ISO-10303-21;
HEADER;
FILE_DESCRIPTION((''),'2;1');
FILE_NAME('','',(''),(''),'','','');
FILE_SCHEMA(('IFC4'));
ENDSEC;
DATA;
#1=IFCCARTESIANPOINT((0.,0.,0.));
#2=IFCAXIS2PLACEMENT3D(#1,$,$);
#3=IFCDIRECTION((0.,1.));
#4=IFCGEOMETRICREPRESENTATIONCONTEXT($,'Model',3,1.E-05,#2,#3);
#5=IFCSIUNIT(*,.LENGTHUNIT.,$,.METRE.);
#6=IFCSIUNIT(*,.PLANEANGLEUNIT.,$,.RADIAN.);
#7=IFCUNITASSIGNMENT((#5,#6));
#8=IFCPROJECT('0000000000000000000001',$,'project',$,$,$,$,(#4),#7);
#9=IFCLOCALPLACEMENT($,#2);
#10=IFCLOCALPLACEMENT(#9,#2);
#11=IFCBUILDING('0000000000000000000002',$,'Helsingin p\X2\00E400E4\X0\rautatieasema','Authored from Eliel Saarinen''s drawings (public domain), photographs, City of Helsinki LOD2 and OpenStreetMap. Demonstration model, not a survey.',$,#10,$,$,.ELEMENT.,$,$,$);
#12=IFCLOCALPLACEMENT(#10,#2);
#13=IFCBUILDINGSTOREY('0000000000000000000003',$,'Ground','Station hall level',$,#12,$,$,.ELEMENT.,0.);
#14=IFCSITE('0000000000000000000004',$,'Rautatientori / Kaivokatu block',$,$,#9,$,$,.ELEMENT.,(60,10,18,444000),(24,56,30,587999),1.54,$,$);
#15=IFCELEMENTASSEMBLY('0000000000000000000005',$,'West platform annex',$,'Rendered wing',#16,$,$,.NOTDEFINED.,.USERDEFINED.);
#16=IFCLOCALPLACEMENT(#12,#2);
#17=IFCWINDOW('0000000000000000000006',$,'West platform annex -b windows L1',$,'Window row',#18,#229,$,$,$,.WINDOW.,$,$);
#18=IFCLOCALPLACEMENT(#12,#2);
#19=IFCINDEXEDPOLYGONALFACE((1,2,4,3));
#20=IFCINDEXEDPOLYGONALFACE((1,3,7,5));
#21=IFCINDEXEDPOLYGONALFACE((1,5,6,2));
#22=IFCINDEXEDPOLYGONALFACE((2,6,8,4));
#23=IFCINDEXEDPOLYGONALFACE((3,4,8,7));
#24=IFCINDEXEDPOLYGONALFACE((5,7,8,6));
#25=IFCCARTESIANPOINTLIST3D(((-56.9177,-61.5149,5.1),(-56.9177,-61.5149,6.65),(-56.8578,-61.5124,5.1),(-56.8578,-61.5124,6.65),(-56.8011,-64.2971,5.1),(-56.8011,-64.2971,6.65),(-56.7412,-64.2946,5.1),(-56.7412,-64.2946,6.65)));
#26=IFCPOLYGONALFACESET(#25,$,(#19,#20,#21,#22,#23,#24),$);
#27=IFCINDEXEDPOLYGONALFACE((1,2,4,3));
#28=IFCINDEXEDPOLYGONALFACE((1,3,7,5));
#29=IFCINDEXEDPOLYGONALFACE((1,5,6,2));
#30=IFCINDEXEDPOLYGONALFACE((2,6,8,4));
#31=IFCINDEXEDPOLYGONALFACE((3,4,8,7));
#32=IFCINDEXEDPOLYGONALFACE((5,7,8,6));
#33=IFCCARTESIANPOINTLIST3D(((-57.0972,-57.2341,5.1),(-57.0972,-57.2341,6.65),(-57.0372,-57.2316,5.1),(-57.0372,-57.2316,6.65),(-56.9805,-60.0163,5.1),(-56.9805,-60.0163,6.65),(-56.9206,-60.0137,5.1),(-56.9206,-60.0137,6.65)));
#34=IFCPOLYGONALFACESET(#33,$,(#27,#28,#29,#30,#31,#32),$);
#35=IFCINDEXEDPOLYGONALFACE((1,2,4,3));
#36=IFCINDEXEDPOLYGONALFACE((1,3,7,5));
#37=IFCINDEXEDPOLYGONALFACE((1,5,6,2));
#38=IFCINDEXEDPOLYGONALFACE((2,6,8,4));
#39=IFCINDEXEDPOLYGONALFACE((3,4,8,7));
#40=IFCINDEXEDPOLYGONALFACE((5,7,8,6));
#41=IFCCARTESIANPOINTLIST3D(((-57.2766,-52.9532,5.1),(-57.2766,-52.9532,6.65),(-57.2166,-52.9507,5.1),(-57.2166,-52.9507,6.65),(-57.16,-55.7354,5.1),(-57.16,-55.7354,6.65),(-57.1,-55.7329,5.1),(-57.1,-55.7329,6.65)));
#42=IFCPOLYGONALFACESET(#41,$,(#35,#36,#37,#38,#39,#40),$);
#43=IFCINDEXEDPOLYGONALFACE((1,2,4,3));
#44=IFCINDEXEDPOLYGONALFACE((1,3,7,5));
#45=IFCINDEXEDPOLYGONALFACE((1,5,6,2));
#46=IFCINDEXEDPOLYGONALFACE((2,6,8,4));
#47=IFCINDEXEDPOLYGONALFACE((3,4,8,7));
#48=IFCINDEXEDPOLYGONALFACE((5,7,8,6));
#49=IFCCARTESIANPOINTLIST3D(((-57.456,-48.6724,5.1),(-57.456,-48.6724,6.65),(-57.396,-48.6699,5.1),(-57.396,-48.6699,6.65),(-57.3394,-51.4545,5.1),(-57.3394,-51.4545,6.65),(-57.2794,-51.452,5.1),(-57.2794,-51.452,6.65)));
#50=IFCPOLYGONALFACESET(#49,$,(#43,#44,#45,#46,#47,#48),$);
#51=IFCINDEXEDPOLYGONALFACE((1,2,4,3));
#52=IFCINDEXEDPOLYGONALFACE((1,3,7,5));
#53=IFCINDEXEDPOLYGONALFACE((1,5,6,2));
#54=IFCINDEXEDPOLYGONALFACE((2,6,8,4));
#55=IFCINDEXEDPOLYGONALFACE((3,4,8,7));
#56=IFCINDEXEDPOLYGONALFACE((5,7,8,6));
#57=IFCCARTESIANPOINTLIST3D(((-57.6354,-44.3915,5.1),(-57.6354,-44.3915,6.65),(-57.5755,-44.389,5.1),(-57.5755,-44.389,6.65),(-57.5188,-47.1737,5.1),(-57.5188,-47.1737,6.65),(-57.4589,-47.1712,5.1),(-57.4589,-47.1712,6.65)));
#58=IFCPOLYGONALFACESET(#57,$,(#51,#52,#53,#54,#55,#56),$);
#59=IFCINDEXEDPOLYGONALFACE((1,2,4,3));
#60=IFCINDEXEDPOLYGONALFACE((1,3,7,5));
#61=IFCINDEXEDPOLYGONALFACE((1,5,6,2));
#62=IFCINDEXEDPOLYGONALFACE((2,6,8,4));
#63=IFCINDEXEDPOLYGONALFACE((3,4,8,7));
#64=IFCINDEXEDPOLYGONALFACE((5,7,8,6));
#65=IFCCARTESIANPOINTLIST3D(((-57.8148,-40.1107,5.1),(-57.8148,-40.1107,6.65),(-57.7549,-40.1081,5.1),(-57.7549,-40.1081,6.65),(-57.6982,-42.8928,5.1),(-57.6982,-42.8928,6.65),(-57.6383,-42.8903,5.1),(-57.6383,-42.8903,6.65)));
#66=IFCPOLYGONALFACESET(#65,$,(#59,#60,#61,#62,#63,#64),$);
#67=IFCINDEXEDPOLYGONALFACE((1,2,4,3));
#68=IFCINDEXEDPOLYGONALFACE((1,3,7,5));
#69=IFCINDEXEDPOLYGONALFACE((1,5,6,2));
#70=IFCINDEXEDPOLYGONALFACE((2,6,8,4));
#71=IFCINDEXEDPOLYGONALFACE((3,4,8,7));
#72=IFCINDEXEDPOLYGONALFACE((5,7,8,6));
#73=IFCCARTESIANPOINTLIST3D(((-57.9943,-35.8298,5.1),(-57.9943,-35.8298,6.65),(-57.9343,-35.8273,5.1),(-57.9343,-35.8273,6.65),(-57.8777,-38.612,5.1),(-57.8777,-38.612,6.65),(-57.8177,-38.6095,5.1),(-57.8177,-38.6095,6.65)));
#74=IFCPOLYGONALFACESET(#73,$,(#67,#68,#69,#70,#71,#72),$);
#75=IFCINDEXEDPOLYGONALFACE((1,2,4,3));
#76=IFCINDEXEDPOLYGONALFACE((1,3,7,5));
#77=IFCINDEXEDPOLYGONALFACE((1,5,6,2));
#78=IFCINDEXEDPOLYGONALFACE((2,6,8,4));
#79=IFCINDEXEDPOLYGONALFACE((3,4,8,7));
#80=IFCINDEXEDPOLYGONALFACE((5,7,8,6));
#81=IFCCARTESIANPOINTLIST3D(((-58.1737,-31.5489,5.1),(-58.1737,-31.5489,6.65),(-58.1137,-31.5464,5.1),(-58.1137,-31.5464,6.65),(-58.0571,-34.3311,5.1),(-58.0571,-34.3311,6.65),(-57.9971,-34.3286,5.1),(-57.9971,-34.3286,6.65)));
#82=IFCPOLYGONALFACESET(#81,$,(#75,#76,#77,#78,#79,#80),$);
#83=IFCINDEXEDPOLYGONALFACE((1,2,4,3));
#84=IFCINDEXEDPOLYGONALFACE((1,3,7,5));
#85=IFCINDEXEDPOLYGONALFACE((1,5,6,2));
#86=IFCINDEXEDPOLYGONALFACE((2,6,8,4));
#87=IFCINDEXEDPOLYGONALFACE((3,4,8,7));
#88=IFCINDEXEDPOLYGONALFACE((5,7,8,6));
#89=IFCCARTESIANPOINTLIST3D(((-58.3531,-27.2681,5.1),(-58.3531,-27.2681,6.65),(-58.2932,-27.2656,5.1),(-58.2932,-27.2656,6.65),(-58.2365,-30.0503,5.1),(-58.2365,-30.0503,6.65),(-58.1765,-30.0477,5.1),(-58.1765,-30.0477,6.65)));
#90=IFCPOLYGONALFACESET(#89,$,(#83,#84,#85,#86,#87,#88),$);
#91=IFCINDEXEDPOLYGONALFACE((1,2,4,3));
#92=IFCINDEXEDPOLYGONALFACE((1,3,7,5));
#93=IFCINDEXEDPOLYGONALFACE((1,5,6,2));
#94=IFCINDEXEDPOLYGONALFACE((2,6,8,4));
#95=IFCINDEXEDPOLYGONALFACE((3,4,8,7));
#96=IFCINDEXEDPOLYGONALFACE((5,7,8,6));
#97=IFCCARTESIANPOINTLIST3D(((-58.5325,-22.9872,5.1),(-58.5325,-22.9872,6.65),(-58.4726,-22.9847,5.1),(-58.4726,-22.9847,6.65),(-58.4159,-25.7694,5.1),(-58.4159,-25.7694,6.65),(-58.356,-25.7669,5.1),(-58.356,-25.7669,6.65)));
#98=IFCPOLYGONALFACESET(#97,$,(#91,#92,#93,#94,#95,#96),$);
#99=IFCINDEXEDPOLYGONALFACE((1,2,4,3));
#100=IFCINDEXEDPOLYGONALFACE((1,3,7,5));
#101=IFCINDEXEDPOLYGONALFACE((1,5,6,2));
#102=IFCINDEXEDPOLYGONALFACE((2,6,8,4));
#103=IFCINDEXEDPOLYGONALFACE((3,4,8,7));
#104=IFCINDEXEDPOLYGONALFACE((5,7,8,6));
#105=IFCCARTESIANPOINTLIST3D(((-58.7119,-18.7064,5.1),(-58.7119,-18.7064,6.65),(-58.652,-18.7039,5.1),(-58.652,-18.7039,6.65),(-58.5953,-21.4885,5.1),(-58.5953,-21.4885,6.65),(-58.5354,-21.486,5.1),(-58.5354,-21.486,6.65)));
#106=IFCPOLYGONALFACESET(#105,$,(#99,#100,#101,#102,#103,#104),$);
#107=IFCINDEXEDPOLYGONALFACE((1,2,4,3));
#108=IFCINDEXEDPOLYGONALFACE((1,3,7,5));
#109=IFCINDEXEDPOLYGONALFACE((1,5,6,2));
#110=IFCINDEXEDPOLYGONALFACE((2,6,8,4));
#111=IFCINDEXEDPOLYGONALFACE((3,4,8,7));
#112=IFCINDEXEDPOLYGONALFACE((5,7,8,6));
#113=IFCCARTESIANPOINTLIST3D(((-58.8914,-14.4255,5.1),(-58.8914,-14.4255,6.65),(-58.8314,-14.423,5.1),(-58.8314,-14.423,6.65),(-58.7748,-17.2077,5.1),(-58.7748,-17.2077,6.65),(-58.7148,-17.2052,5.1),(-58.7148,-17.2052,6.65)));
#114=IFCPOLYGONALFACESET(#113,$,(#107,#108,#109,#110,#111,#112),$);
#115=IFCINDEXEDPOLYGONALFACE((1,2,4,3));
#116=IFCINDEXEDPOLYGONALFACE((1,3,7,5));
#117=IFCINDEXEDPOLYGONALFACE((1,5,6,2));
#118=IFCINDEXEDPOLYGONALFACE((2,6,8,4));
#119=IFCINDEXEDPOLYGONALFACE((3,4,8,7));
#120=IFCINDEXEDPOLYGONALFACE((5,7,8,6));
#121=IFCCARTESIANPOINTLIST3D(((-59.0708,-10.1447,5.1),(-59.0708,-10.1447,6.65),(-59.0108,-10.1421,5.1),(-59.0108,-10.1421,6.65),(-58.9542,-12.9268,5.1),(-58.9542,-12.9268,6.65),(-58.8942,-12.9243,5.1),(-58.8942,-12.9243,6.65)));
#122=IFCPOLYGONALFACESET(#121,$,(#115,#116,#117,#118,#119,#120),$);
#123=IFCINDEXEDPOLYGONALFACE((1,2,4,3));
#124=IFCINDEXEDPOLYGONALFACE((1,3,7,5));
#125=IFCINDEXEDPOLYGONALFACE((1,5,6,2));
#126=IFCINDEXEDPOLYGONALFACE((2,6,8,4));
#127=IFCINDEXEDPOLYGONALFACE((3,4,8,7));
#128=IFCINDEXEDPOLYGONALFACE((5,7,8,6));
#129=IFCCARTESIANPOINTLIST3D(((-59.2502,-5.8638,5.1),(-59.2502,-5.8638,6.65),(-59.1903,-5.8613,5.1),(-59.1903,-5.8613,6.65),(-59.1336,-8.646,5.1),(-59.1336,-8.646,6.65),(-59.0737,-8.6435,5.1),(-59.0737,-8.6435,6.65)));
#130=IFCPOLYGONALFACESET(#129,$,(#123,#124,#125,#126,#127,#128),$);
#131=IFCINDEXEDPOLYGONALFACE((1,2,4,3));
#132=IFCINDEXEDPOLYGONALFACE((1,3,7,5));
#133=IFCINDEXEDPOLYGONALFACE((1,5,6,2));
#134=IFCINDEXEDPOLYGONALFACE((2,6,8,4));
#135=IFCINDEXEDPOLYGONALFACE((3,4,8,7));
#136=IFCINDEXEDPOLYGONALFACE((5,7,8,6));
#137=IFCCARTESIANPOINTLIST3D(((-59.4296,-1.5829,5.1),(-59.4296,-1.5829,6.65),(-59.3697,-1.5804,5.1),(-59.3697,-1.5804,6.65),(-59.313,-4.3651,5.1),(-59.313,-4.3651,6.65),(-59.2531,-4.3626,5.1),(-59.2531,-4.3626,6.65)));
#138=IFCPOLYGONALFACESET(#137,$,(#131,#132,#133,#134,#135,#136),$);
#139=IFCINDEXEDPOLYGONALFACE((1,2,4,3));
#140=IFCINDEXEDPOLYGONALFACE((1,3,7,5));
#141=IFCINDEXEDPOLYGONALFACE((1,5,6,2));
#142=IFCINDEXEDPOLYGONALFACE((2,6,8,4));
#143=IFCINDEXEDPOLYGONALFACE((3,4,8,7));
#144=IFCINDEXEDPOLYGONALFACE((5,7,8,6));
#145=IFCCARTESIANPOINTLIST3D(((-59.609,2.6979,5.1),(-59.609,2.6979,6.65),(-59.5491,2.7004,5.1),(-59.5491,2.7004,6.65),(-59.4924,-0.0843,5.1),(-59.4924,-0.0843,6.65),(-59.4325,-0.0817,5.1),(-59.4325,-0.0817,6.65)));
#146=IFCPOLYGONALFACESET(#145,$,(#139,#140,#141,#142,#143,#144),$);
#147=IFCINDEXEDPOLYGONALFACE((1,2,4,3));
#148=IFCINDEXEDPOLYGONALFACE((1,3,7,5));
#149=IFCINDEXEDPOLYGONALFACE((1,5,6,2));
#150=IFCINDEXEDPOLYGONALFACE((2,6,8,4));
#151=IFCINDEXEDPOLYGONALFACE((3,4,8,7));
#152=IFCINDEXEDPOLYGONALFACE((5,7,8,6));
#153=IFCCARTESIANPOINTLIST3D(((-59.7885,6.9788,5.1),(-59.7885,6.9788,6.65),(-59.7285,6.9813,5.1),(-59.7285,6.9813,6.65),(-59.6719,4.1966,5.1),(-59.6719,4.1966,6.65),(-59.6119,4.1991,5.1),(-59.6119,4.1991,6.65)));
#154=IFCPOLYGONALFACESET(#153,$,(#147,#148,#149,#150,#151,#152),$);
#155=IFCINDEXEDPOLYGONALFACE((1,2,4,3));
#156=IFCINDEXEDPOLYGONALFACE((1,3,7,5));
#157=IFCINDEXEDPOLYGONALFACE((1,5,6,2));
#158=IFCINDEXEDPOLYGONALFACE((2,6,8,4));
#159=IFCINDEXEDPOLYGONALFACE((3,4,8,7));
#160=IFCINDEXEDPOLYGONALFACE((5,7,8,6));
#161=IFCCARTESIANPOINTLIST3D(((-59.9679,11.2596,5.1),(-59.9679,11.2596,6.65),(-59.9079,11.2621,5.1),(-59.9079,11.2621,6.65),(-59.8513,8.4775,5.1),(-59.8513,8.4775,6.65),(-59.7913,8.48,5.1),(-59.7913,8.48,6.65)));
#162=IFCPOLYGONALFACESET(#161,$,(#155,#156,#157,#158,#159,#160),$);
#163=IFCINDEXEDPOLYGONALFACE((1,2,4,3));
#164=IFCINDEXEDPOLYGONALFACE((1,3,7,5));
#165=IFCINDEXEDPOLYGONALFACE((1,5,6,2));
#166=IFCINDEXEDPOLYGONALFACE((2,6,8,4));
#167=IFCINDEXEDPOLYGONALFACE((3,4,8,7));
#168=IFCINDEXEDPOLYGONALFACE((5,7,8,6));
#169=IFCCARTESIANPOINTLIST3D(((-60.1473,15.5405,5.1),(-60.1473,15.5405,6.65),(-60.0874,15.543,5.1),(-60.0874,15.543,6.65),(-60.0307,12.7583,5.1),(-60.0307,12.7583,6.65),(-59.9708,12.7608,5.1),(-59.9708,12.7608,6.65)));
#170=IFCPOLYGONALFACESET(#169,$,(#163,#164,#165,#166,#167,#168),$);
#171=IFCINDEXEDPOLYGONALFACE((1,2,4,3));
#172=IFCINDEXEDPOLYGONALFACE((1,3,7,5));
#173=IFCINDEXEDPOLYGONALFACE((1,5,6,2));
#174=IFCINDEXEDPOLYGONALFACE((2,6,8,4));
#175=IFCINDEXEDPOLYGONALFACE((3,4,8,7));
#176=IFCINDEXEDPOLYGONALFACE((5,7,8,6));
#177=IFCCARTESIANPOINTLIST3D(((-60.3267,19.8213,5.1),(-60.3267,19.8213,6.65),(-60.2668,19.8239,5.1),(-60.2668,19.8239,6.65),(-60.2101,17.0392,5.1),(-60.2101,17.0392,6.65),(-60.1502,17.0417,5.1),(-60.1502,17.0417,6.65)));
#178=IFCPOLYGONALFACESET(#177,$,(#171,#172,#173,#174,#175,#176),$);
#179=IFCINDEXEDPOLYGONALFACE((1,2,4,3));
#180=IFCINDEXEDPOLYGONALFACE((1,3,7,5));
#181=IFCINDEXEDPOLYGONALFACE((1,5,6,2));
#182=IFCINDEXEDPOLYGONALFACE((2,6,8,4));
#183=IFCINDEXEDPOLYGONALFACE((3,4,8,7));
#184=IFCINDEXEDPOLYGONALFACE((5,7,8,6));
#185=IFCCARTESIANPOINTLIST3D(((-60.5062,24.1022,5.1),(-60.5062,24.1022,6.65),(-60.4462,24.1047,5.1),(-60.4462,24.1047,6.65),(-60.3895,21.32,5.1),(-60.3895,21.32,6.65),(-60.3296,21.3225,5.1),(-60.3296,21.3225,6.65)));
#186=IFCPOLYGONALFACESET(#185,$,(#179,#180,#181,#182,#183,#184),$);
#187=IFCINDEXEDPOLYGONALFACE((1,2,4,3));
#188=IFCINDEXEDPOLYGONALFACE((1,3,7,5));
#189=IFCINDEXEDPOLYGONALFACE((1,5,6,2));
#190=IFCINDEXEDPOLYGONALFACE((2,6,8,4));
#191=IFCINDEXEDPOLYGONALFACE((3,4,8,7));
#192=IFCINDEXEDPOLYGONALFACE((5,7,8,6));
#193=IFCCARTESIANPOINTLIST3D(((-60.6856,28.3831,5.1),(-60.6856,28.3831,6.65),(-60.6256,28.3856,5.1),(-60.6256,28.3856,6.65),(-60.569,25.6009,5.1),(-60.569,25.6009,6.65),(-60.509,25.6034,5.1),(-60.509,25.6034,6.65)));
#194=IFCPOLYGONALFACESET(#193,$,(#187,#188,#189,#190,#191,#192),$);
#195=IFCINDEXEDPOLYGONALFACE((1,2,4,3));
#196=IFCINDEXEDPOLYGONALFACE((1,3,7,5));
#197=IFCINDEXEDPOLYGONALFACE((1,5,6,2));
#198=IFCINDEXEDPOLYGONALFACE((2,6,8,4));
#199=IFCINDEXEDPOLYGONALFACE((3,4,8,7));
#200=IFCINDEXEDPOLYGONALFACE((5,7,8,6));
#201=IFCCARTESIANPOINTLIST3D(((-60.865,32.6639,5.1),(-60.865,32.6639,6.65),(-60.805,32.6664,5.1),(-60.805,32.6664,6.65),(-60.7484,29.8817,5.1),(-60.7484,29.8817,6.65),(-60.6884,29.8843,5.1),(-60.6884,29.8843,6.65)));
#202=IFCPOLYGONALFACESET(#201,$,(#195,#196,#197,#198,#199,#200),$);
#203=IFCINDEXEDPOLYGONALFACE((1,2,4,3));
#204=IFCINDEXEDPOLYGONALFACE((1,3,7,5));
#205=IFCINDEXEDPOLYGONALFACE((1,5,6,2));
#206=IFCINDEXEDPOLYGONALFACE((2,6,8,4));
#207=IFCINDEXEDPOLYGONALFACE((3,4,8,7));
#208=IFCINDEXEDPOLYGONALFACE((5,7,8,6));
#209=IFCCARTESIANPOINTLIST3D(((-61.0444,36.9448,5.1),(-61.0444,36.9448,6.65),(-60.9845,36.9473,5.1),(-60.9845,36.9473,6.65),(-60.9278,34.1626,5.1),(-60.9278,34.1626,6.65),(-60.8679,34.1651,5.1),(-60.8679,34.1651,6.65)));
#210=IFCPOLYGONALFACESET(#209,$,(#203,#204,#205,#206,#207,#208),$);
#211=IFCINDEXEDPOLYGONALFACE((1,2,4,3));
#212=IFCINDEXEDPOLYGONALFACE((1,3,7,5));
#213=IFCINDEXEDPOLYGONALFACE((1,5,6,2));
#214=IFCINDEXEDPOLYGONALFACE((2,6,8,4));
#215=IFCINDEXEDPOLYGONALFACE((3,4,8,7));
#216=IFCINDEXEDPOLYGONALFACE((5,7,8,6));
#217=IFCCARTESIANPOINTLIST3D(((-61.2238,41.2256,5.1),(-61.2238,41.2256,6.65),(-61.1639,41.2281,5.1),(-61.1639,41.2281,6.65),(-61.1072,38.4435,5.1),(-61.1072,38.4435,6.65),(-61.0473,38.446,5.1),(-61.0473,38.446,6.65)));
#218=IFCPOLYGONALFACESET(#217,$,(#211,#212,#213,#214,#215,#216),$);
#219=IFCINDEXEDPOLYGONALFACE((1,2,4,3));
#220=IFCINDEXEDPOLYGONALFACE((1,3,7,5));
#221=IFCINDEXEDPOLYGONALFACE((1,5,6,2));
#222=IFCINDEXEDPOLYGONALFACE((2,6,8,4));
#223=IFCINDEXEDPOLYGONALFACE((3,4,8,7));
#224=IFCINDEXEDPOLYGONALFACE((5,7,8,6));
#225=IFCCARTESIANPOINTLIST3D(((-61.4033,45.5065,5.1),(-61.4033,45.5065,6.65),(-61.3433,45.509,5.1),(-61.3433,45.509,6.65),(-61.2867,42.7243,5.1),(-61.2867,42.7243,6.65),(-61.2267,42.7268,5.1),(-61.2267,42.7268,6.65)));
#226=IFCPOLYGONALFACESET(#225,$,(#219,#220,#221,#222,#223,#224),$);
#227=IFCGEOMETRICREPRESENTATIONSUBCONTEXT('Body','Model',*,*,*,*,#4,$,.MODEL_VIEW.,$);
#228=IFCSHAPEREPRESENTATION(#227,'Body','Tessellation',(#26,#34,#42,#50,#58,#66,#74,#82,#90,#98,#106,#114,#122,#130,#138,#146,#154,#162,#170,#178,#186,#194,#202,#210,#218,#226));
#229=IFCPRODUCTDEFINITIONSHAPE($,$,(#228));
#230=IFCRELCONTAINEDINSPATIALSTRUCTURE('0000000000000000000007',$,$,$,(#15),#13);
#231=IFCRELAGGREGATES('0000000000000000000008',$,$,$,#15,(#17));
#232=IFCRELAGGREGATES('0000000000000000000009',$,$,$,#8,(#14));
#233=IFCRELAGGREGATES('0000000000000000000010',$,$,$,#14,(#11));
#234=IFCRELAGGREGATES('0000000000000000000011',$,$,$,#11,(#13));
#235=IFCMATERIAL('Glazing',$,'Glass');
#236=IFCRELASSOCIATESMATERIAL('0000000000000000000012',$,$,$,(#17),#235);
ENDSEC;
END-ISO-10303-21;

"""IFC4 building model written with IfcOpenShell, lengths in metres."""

from ifc_helpers import new_model, si_unit, direction, frame, frame_2d, origin, place, context, subcontext, project, spatial, rectangle, extrude, material, element, aggregate, save


model = new_model("IFC4")

# Units and contexts
model_context = context("Model", 3, precision=1e-05, world=origin(), true_north=direction((0.0, 1.0)))
body_context = subcontext(model_context, "Body", "Model", "MODEL_VIEW")
ifc_project = project(units=[si_unit("LENGTHUNIT", "METRE"), si_unit("PLANEANGLEUNIT", "RADIAN")], contexts=[model_context])

# Site, building, storey
site_placement = place(None, origin())
site = spatial("IfcSite", under=ifc_project, at=site_placement, Name="Rautatientori / Kaivokatu block", CompositionType="ELEMENT", RefLatitude=(60, 10, 18, 444000), RefLongitude=(24, 56, 30, 587999), RefElevation=1.54)
building_placement = place(site_placement, origin())
building = spatial("IfcBuilding", under=site, at=building_placement, Name="Helsingin päärautatieasema", Description="Authored from Eliel Saarinen's drawings (public domain), photographs, City of Helsinki LOD2 and OpenStreetMap. Demonstration model, not a survey.", CompositionType="ELEMENT")
storey_placement = place(building_placement, origin())
storey = spatial("IfcBuildingStorey", under=building, at=storey_placement, Name="Ground", Description="Station hall level", CompositionType="ELEMENT", Elevation=0.0)

# Element assembly
assembly_1_placement = place(building_placement, origin())
assembly_1 = element("IfcElementAssembly", 1, at=assembly_1_placement, inside=storey, Name="West platform annex", ObjectType="Rendered wing", AssemblyPlace="NOTDEFINED", PredefinedType="USERDEFINED")

# Shared definitions
ifc_material_1 = material(Name="Glazing", Category="Glass")

# Window
window_1_placement = place(building_placement, origin())
window_1 = element("IfcWindow", 2, at=window_1_placement, material=ifc_material_1, Name="West platform annex -b windows L1", ObjectType="Window row", PredefinedType="WINDOW", context=body_context, shape_type="SweptSolid", body=[
    extrude(rectangle(XDim=2.7846, YDim=0.06, at=frame_2d((0.0, 0.0), x_axis=(-0.041876, 0.999123))), frame((-56.8295, -62.9048, 5.1)), (0.0, 0.0, 1.0), 1.55),
    extrude(rectangle(XDim=2.7846, YDim=0.06, at=frame_2d((0.0, 0.0), x_axis=(-0.041876, 0.999123))), frame((-57.0089, -58.6239, 5.1)), (0.0, 0.0, 1.0), 1.55),
    extrude(rectangle(XDim=2.7846, YDim=0.06, at=frame_2d((0.0, 0.0), x_axis=(-0.041876, 0.999123))), frame((-57.1883, -54.3431, 5.1)), (0.0, 0.0, 1.0), 1.55),
    extrude(rectangle(XDim=2.7846, YDim=0.06, at=frame_2d((0.0, 0.0), x_axis=(-0.041876, 0.999123))), frame((-57.3677, -50.0622, 5.1)), (0.0, 0.0, 1.0), 1.55),
    extrude(rectangle(XDim=2.7846, YDim=0.06, at=frame_2d((0.0, 0.0), x_axis=(-0.041876, 0.999123))), frame((-57.5471, -45.7813, 5.1)), (0.0, 0.0, 1.0), 1.55),
    extrude(rectangle(XDim=2.7846, YDim=0.06, at=frame_2d((0.0, 0.0), x_axis=(-0.041876, 0.999123))), frame((-57.7266, -41.5005, 5.1)), (0.0, 0.0, 1.0), 1.55),
    extrude(rectangle(XDim=2.7846, YDim=0.06, at=frame_2d((0.0, 0.0), x_axis=(-0.041876, 0.999123))), frame((-57.906, -37.2196, 5.1)), (0.0, 0.0, 1.0), 1.55),
    extrude(rectangle(XDim=2.7846, YDim=0.06, at=frame_2d((0.0, 0.0), x_axis=(-0.041876, 0.999123))), frame((-58.0854, -32.9388, 5.1)), (0.0, 0.0, 1.0), 1.55),
    extrude(rectangle(XDim=2.7846, YDim=0.06, at=frame_2d((0.0, 0.0), x_axis=(-0.041876, 0.999123))), frame((-58.2648, -28.6579, 5.1)), (0.0, 0.0, 1.0), 1.55),
    extrude(rectangle(XDim=2.7846, YDim=0.06, at=frame_2d((0.0, 0.0), x_axis=(-0.041876, 0.999123))), frame((-58.4442, -24.3771, 5.1)), (0.0, 0.0, 1.0), 1.55),
    extrude(rectangle(XDim=2.7846, YDim=0.06, at=frame_2d((0.0, 0.0), x_axis=(-0.041876, 0.999123))), frame((-58.6237, -20.0962, 5.1)), (0.0, 0.0, 1.0), 1.55),
    extrude(rectangle(XDim=2.7846, YDim=0.06, at=frame_2d((0.0, 0.0), x_axis=(-0.041876, 0.999123))), frame((-58.8031, -15.8153, 5.1)), (0.0, 0.0, 1.0), 1.55),
    extrude(rectangle(XDim=2.7846, YDim=0.06, at=frame_2d((0.0, 0.0), x_axis=(-0.041876, 0.999123))), frame((-58.9825, -11.5345, 5.1)), (0.0, 0.0, 1.0), 1.55),
    extrude(rectangle(XDim=2.7846, YDim=0.06, at=frame_2d((0.0, 0.0), x_axis=(-0.041876, 0.999123))), frame((-59.1619, -7.2536, 5.1)), (0.0, 0.0, 1.0), 1.55),
    extrude(rectangle(XDim=2.7846, YDim=0.06, at=frame_2d((0.0, 0.0), x_axis=(-0.041876, 0.999123))), frame((-59.3414, -2.9728, 5.1)), (0.0, 0.0, 1.0), 1.55),
    extrude(rectangle(XDim=2.7846, YDim=0.06, at=frame_2d((0.0, 0.0), x_axis=(-0.041876, 0.999123))), frame((-59.5208, 1.3081, 5.1)), (0.0, 0.0, 1.0), 1.55),
    extrude(rectangle(XDim=2.7846, YDim=0.06, at=frame_2d((0.0, 0.0), x_axis=(-0.041876, 0.999123))), frame((-59.7002, 5.5889, 5.1)), (0.0, 0.0, 1.0), 1.55),
    extrude(rectangle(XDim=2.7846, YDim=0.06, at=frame_2d((0.0, 0.0), x_axis=(-0.041876, 0.999123))), frame((-59.8796, 9.8698, 5.1)), (0.0, 0.0, 1.0), 1.55),
    extrude(rectangle(XDim=2.7846, YDim=0.06, at=frame_2d((0.0, 0.0), x_axis=(-0.041876, 0.999123))), frame((-60.059, 14.1507, 5.1)), (0.0, 0.0, 1.0), 1.55),
    extrude(rectangle(XDim=2.7846, YDim=0.06, at=frame_2d((0.0, 0.0), x_axis=(-0.041876, 0.999123))), frame((-60.2385, 18.4315, 5.1)), (0.0, 0.0, 1.0), 1.55),
    extrude(rectangle(XDim=2.7846, YDim=0.06, at=frame_2d((0.0, 0.0), x_axis=(-0.041876, 0.999123))), frame((-60.4179, 22.7124, 5.1)), (0.0, 0.0, 1.0), 1.55),
    extrude(rectangle(XDim=2.7846, YDim=0.06, at=frame_2d((0.0, 0.0), x_axis=(-0.041876, 0.999123))), frame((-60.5973, 26.9932, 5.1)), (0.0, 0.0, 1.0), 1.55),
    extrude(rectangle(XDim=2.7846, YDim=0.06, at=frame_2d((0.0, 0.0), x_axis=(-0.041876, 0.999123))), frame((-60.7767, 31.2741, 5.1)), (0.0, 0.0, 1.0), 1.55),
    extrude(rectangle(XDim=2.7846, YDim=0.06, at=frame_2d((0.0, 0.0), x_axis=(-0.041876, 0.999123))), frame((-60.9561, 35.5549, 5.1)), (0.0, 0.0, 1.0), 1.55),
    extrude(rectangle(XDim=2.7846, YDim=0.06, at=frame_2d((0.0, 0.0), x_axis=(-0.041876, 0.999123))), frame((-61.1356, 39.8358, 5.1)), (0.0, 0.0, 1.0), 1.55),
    extrude(rectangle(XDim=2.7846, YDim=0.06, at=frame_2d((0.0, 0.0), x_axis=(-0.041876, 0.999123))), frame((-61.315, 44.1167, 5.1)), (0.0, 0.0, 1.0), 1.55),
])

aggregate(assembly_1, [window_1])

save(model, "model.ifc")
